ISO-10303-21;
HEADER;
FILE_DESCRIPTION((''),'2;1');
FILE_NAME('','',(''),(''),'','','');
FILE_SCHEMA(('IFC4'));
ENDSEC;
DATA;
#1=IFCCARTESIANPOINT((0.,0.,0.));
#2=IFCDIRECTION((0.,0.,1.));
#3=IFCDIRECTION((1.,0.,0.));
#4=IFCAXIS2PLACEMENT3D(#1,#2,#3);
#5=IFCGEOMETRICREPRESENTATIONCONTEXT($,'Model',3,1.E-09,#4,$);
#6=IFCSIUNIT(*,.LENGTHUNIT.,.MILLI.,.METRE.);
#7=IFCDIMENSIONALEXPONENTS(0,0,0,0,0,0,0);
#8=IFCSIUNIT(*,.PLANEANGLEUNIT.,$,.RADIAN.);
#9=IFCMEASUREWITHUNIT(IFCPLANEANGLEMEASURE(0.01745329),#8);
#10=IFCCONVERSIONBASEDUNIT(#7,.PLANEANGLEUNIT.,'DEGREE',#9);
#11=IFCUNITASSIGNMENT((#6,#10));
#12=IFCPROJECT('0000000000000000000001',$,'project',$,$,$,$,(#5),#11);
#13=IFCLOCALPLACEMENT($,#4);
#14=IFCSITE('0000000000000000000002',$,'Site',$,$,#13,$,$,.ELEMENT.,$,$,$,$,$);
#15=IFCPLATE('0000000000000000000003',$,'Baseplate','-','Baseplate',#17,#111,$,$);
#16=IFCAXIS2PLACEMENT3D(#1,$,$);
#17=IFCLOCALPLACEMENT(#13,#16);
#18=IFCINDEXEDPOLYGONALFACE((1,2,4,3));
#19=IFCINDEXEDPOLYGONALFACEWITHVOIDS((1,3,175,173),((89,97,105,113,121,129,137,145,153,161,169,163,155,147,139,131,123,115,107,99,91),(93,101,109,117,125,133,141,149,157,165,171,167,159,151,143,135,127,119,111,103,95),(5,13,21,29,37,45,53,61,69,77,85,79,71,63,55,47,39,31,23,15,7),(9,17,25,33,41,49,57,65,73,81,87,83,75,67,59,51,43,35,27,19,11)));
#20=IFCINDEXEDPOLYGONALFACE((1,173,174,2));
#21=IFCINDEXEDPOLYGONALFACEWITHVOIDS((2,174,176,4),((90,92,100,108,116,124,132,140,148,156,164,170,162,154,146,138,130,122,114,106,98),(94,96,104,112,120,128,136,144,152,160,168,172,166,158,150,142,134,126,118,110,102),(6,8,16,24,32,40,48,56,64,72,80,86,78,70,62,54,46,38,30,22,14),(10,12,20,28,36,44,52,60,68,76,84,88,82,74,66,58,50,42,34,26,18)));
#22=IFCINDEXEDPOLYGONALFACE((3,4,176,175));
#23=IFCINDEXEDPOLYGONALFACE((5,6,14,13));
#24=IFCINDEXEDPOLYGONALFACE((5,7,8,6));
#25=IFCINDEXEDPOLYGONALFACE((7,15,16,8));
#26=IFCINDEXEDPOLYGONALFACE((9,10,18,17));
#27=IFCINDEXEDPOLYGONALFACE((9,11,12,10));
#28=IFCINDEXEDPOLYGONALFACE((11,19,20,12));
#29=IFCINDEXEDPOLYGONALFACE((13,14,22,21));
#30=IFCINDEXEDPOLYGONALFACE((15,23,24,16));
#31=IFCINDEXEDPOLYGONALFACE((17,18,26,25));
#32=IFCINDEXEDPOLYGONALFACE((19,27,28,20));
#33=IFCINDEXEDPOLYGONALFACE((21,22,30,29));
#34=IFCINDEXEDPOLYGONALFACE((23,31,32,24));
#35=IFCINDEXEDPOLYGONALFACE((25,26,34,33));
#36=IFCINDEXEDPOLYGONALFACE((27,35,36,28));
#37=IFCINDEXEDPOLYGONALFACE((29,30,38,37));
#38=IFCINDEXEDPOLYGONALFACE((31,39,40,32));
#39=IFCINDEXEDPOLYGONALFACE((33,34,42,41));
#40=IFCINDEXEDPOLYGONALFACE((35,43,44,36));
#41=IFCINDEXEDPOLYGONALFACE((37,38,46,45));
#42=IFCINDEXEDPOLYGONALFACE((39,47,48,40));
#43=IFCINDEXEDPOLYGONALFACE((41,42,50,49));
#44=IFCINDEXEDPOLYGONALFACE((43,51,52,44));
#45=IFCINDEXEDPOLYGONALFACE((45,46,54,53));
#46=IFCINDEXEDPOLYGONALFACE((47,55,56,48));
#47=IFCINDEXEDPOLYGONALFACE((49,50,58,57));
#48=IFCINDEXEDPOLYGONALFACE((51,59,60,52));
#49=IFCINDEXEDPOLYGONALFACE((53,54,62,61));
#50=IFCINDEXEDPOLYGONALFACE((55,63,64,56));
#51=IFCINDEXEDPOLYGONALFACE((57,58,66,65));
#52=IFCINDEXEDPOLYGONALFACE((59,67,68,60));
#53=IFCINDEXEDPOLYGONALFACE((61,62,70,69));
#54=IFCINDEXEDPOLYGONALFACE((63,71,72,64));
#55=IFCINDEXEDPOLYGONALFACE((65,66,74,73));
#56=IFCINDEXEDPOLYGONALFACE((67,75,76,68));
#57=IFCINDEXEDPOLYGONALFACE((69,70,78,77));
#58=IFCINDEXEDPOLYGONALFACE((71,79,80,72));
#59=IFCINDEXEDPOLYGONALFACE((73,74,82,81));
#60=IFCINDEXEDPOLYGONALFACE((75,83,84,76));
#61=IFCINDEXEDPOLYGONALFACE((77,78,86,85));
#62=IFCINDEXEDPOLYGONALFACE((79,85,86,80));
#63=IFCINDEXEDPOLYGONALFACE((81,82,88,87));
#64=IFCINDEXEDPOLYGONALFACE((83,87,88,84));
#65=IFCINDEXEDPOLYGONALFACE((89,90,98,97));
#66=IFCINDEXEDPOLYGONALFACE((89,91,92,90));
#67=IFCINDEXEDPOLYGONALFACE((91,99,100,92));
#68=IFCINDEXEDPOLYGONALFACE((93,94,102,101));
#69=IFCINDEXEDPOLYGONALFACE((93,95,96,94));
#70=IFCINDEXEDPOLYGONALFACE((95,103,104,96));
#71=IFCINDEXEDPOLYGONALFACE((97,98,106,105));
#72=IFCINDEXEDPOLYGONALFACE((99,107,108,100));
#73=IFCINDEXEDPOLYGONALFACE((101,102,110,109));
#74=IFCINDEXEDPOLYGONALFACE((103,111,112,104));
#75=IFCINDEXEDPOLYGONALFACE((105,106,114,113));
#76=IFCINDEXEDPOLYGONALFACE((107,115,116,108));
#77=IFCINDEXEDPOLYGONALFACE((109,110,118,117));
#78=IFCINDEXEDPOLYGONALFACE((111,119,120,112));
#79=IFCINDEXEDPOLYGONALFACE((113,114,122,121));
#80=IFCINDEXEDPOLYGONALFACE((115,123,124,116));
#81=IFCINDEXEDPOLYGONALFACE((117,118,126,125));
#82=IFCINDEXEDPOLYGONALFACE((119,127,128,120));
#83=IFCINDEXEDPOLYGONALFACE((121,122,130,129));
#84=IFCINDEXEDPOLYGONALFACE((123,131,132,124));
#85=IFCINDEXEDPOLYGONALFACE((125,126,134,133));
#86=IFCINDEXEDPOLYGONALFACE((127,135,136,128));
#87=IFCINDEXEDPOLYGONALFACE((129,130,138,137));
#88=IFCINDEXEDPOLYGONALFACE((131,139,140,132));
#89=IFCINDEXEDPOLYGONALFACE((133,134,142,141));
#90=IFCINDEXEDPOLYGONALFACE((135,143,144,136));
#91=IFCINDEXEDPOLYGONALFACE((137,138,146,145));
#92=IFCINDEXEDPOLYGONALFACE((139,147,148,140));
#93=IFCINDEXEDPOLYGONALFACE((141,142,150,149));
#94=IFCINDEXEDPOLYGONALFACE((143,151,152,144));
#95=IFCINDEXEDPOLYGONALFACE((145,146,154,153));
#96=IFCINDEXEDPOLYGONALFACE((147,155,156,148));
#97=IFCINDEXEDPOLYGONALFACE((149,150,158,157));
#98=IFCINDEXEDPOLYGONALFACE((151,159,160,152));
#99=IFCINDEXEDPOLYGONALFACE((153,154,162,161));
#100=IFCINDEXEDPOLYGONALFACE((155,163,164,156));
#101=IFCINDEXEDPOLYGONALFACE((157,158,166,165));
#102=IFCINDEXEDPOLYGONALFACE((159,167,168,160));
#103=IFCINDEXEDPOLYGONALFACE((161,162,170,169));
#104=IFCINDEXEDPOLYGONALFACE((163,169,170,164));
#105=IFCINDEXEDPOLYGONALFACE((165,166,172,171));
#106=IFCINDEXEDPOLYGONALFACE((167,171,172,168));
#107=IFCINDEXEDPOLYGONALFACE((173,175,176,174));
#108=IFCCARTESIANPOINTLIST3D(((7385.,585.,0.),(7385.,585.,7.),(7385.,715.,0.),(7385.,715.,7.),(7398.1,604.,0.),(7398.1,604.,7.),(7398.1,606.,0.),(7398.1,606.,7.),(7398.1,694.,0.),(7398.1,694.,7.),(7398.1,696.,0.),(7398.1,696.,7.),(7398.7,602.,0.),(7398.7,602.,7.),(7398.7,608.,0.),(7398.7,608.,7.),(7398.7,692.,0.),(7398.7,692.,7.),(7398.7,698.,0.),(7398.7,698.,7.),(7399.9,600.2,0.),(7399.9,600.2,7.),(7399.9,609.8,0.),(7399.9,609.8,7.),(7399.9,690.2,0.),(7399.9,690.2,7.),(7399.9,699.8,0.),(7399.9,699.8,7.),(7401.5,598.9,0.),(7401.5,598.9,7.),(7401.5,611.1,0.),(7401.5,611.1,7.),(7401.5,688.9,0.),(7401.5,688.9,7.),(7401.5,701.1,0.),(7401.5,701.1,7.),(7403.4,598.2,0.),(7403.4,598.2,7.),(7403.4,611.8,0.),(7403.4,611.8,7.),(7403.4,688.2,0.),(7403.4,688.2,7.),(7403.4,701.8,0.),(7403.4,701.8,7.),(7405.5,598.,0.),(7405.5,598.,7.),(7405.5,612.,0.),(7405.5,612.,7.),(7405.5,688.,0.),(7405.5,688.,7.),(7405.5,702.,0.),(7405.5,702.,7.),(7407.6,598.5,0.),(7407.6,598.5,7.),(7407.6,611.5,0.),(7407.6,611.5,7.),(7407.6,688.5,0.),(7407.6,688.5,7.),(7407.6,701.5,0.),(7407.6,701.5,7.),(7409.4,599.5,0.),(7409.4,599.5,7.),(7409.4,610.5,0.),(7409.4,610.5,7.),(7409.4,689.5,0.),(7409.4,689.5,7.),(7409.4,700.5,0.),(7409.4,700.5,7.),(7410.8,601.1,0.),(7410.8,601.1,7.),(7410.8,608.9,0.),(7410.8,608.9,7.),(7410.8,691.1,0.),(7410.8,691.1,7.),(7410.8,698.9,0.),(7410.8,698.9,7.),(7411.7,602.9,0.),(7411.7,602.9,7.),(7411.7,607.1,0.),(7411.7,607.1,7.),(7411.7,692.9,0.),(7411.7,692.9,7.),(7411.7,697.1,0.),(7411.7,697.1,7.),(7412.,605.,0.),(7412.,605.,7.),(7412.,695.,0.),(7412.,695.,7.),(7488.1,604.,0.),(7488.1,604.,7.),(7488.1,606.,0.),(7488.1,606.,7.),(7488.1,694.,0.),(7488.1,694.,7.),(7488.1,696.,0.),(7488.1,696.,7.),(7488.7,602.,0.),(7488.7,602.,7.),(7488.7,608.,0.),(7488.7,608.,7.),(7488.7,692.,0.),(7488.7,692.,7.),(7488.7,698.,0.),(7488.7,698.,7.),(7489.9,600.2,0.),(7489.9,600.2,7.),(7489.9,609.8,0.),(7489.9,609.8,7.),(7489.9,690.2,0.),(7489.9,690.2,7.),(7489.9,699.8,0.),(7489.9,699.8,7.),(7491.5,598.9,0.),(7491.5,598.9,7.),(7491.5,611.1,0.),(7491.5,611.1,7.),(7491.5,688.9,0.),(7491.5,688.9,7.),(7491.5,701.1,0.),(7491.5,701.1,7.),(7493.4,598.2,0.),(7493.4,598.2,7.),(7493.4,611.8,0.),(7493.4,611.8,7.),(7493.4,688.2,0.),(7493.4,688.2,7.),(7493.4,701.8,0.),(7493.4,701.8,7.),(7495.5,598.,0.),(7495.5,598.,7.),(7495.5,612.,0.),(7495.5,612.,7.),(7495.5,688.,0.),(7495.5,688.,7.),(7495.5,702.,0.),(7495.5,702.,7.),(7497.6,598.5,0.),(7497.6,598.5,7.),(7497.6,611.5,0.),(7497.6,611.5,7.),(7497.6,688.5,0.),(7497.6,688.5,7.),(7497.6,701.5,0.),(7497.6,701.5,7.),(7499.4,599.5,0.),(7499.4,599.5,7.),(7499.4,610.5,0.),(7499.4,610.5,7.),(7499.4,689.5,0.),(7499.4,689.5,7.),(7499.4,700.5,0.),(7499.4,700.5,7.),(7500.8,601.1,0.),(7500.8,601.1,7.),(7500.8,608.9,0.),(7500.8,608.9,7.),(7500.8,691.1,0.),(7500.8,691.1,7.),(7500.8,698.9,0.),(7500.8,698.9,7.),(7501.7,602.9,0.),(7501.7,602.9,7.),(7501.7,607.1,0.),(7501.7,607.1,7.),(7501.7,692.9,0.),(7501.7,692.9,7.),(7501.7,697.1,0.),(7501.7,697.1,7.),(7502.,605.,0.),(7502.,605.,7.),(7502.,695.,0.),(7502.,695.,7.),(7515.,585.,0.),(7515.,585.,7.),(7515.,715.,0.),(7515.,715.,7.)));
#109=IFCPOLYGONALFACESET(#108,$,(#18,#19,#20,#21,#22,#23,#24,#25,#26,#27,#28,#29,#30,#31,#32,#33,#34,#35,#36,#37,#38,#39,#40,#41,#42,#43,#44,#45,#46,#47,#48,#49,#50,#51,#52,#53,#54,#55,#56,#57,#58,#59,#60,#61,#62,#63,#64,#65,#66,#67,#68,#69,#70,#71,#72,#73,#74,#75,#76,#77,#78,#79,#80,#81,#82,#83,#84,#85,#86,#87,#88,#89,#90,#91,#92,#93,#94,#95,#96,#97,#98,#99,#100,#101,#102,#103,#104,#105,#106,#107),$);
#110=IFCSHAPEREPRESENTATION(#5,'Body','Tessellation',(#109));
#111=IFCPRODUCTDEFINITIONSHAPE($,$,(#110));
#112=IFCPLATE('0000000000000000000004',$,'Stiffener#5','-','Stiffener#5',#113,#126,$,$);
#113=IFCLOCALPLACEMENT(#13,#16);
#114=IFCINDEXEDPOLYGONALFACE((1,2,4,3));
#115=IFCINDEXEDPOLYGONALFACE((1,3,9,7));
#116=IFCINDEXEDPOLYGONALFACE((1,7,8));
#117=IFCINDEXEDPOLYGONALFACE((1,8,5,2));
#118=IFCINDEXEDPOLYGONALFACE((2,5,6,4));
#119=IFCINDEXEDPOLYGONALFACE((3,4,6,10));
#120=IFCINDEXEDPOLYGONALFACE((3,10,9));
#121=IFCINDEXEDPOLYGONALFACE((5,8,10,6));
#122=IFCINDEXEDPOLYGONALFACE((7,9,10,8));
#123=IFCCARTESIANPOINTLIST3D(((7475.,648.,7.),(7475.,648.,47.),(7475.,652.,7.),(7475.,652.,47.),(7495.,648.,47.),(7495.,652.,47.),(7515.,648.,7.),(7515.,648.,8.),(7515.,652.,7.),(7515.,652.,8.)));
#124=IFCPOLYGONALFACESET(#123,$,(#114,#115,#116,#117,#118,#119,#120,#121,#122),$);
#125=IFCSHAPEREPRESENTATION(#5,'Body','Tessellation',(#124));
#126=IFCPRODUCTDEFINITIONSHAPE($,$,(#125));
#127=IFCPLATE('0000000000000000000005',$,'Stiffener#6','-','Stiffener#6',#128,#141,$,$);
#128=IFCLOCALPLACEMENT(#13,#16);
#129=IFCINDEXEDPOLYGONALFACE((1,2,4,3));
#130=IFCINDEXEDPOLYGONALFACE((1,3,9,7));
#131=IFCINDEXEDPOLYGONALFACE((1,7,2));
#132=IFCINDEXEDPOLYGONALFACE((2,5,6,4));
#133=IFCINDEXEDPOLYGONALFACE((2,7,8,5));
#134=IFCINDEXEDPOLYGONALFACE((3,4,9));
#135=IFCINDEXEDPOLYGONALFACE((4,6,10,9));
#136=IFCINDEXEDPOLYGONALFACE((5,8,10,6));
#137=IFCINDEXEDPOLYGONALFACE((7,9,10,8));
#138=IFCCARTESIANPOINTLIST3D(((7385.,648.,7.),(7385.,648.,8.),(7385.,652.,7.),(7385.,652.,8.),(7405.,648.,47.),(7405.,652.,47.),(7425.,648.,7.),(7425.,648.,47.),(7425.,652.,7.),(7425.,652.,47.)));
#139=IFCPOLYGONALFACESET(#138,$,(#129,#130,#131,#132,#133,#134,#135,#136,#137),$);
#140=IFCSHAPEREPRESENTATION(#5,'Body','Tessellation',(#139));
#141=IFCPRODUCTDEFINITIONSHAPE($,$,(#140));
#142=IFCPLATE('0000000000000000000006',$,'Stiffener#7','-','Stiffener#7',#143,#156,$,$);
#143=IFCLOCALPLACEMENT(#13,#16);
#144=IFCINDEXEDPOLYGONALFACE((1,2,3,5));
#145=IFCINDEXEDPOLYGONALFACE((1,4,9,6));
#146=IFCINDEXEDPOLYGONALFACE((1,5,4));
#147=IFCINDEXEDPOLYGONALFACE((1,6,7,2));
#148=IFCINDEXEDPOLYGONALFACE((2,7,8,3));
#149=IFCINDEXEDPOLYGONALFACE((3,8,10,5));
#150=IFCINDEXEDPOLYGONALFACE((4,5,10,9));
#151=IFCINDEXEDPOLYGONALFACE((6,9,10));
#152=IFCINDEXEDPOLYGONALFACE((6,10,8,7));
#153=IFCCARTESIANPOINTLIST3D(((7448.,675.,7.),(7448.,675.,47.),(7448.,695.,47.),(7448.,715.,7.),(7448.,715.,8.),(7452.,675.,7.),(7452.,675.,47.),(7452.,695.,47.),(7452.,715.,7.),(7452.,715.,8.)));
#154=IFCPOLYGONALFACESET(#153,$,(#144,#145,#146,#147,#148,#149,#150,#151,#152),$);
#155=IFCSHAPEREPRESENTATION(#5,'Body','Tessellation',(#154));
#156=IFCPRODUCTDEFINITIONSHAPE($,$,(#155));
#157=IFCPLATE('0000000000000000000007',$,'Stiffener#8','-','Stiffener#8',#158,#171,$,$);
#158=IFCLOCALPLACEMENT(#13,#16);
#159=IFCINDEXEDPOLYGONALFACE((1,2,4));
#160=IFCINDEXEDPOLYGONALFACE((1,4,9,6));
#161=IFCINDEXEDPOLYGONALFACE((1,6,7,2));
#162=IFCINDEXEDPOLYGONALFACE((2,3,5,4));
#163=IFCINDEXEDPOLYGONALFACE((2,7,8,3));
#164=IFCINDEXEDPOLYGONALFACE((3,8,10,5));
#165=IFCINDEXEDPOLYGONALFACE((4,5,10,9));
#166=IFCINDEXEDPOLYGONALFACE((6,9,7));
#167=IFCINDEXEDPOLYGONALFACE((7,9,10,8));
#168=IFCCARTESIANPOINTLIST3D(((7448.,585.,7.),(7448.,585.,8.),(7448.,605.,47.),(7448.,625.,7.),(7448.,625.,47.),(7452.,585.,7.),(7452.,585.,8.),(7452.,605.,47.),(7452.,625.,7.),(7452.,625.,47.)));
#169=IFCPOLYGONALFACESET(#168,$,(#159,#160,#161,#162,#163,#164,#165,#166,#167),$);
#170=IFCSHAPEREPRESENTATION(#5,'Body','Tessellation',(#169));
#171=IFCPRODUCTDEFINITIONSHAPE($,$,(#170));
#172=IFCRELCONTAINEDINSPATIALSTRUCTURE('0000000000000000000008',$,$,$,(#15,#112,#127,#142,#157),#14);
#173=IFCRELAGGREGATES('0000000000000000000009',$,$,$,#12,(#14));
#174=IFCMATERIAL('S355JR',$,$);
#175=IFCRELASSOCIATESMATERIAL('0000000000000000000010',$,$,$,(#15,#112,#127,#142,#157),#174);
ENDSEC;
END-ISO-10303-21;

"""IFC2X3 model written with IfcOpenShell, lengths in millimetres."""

from ifc_helpers import new_model, entity, si_unit, converted_unit, frame, frame_2d, origin, origin_with_axes, place, context, project, spatial, polyline, circle, outline, extrude, material, element, save


model = new_model("IFC2X3")

# Units and contexts
model_context = context("Model", 3, precision=1e-09, world=origin_with_axes())
ifc_project = project(units=[si_unit("LENGTHUNIT", "METRE", prefix="MILLI"), converted_unit("PLANEANGLEUNIT", "DEGREE", entity("IfcPlaneAngleMeasure", 0.01745329), si_unit("PLANEANGLEUNIT", "RADIAN"), dimensions=[0, 0, 0, 0, 0, 0, 0])], contexts=[model_context])

# Site
site_placement = place(None, origin_with_axes())
site = spatial("IfcSite", under=ifc_project, at=site_placement, Name="Site", CompositionType="ELEMENT")

# Shared definitions
ifc_material = material(Name="S355JR")

# Plate, openings
plate_1_placement = place(None, frame((7385.0, 715.0, 7.0), z_axis=(0.0, 0.0, -1.0), x_axis=(1.0, 0.0, 0.0)))
plate_1 = element("IfcPlate", 1, at=plate_1_placement, inside=site, material=ifc_material, Name="Baseplate", Description="-", ObjectType="Baseplate", context=model_context, shape_type="SweptSolid", body=[
    extrude(outline(polyline([(0.0, 0.0), (130.0, 0.0), (130.0, 130.0), (0.0, 130.0), (0.0, 0.0)])), origin_with_axes(), (0.0, 0.0, 1.0), 7.0),
])
opening_1_placement = place(plate_1_placement, frame((110.0, 65.0, 7.5), z_axis=(0.0, 0.0, -1.0), x_axis=(1.0, 0.0, 0.0)))
element("IfcOpeningElement", 2, at=opening_1_placement, cuts=plate_1, ObjectType="Opening", context=model_context, shape_type="SweptSolid", body=[
    extrude(circle(Radius=7.0, at=frame_2d((0.0, 45.0), x_axis=(1.0, 0.0))), origin(), (0.0, 0.0, 1.0), 8.0),
])
opening_2_placement = place(plate_1_placement, frame((110.0, 65.0, 7.5), z_axis=(0.0, 0.0, -1.0), x_axis=(1.0, 0.0, 0.0)))
element("IfcOpeningElement", 3, at=opening_2_placement, cuts=plate_1, ObjectType="Opening", context=model_context, shape_type="SweptSolid", body=[
    extrude(circle(Radius=7.0, at=frame_2d((0.0, -45.0), x_axis=(1.0, 0.0))), origin(), (0.0, 0.0, 1.0), 8.0),
])
opening_3_placement = place(plate_1_placement, frame((20.0, 65.0, 7.5), z_axis=(0.0, 0.0, -1.0), x_axis=(1.0, 0.0, 0.0)))
element("IfcOpeningElement", 4, at=opening_3_placement, cuts=plate_1, ObjectType="Opening", context=model_context, shape_type="SweptSolid", body=[
    extrude(circle(Radius=7.0, at=frame_2d((0.0, 45.0), x_axis=(1.0, 0.0))), origin(), (0.0, 0.0, 1.0), 8.0),
])
opening_4_placement = place(plate_1_placement, frame((20.0, 65.0, 7.5), z_axis=(0.0, 0.0, -1.0), x_axis=(1.0, 0.0, 0.0)))
element("IfcOpeningElement", 5, at=opening_4_placement, cuts=plate_1, ObjectType="Opening", context=model_context, shape_type="SweptSolid", body=[
    extrude(circle(Radius=7.0, at=frame_2d((0.0, -45.0), x_axis=(1.0, 0.0))), origin(), (0.0, 0.0, 1.0), 8.0),
])

# Plates, openings
plate_2_placement = place(None, frame((7475.0, 648.0, 7.0), z_axis=(0.0, 1.0, 0.0), x_axis=(0.0, 0.0, 1.0)))
plate_2 = element("IfcPlate", 6, at=plate_2_placement, inside=site, material=ifc_material, Name="Stiffener#5", Description="-", ObjectType="Stiffener#5", context=model_context, shape_type="SweptSolid", body=[
    extrude(outline(polyline([(0.0, 0.0), (40.0, 0.0), (40.0, 40.0), (0.0, 40.0), (0.0, 0.0)])), origin_with_axes(), (0.0, 0.0, 1.0), 4.0),
])
opening_5_placement = place(plate_2_placement, frame((0.0, 0.0, 0.0), z_axis=(0.0, 0.0, 1.0), x_axis=(1.0, 0.0, 0.0)))
element("IfcOpeningElement", 7, at=opening_5_placement, cuts=plate_2, ObjectType="Opening", context=model_context, shape_type="SweptSolid", body=[
    extrude(outline(polyline([(40.0, 40.0), (1.0, 40.0), (40.0, 20.0), (40.0, 40.0)])), origin(), (0.0, 0.0, 1.0), 4.0),
])
plate_3_placement = place(None, frame((7425.0, 648.0, 7.0), z_axis=(0.0, 1.0, 0.0), x_axis=(-1.0, 0.0, 0.0)))
plate_3 = element("IfcPlate", 8, at=plate_3_placement, inside=site, material=ifc_material, Name="Stiffener#6", Description="-", ObjectType="Stiffener#6", context=model_context, shape_type="SweptSolid", body=[
    extrude(outline(polyline([(0.0, 0.0), (40.0, 0.0), (40.0, 40.0), (0.0, 40.0), (0.0, 0.0)])), origin_with_axes(), (0.0, 0.0, 1.0), 4.0),
])
opening_6_placement = place(plate_3_placement, frame((0.0, 0.0, 0.0), z_axis=(0.0, 0.0, 1.0), x_axis=(1.0, 0.0, 0.0)))
element("IfcOpeningElement", 9, at=opening_6_placement, cuts=plate_3, ObjectType="Opening", context=model_context, shape_type="SweptSolid", body=[
    extrude(outline(polyline([(40.0, 40.0), (20.0, 40.0), (40.0, 1.0), (40.0, 40.0)])), origin(), (0.0, 0.0, 1.0), 4.0),
])
plate_4_placement = place(None, frame((7452.0, 675.0, 7.0), z_axis=(-1.0, 0.0, 0.0), x_axis=(0.0, 0.0, 1.0)))
plate_4 = element("IfcPlate", 10, at=plate_4_placement, inside=site, material=ifc_material, Name="Stiffener#7", Description="-", ObjectType="Stiffener#7", context=model_context, shape_type="SweptSolid", body=[
    extrude(outline(polyline([(0.0, 0.0), (40.0, 0.0), (40.0, 40.0), (0.0, 40.0), (0.0, 0.0)])), origin_with_axes(), (0.0, 0.0, 1.0), 4.0),
])
opening_7_placement = place(plate_4_placement, frame((0.0, 0.0, 0.0), z_axis=(0.0, 0.0, 1.0), x_axis=(1.0, 0.0, 0.0)))
element("IfcOpeningElement", 11, at=opening_7_placement, cuts=plate_4, ObjectType="Opening", context=model_context, shape_type="SweptSolid", body=[
    extrude(outline(polyline([(40.0, 40.0), (1.0, 40.0), (40.0, 20.0), (40.0, 40.0)])), origin(), (0.0, 0.0, 1.0), 4.0),
])
plate_5_placement = place(None, frame((7452.0, 625.0, 7.0), z_axis=(-1.0, 0.0, 0.0), x_axis=(0.0, -1.0, 0.0)))
plate_5 = element("IfcPlate", 12, at=plate_5_placement, inside=site, material=ifc_material, Name="Stiffener#8", Description="-", ObjectType="Stiffener#8", context=model_context, shape_type="SweptSolid", body=[
    extrude(outline(polyline([(0.0, 0.0), (40.0, 0.0), (40.0, 40.0), (0.0, 40.0), (0.0, 0.0)])), origin_with_axes(), (0.0, 0.0, 1.0), 4.0),
])
opening_8_placement = place(plate_5_placement, frame((0.0, 0.0, 0.0), z_axis=(0.0, 0.0, 1.0), x_axis=(1.0, 0.0, 0.0)))
element("IfcOpeningElement", 13, at=opening_8_placement, cuts=plate_5, ObjectType="Opening", context=model_context, shape_type="SweptSolid", body=[
    extrude(outline(polyline([(40.0, 40.0), (20.0, 40.0), (40.0, 1.0), (40.0, 40.0)])), origin(), (0.0, 0.0, 1.0), 4.0),
])

save(model, "model.ifc")
